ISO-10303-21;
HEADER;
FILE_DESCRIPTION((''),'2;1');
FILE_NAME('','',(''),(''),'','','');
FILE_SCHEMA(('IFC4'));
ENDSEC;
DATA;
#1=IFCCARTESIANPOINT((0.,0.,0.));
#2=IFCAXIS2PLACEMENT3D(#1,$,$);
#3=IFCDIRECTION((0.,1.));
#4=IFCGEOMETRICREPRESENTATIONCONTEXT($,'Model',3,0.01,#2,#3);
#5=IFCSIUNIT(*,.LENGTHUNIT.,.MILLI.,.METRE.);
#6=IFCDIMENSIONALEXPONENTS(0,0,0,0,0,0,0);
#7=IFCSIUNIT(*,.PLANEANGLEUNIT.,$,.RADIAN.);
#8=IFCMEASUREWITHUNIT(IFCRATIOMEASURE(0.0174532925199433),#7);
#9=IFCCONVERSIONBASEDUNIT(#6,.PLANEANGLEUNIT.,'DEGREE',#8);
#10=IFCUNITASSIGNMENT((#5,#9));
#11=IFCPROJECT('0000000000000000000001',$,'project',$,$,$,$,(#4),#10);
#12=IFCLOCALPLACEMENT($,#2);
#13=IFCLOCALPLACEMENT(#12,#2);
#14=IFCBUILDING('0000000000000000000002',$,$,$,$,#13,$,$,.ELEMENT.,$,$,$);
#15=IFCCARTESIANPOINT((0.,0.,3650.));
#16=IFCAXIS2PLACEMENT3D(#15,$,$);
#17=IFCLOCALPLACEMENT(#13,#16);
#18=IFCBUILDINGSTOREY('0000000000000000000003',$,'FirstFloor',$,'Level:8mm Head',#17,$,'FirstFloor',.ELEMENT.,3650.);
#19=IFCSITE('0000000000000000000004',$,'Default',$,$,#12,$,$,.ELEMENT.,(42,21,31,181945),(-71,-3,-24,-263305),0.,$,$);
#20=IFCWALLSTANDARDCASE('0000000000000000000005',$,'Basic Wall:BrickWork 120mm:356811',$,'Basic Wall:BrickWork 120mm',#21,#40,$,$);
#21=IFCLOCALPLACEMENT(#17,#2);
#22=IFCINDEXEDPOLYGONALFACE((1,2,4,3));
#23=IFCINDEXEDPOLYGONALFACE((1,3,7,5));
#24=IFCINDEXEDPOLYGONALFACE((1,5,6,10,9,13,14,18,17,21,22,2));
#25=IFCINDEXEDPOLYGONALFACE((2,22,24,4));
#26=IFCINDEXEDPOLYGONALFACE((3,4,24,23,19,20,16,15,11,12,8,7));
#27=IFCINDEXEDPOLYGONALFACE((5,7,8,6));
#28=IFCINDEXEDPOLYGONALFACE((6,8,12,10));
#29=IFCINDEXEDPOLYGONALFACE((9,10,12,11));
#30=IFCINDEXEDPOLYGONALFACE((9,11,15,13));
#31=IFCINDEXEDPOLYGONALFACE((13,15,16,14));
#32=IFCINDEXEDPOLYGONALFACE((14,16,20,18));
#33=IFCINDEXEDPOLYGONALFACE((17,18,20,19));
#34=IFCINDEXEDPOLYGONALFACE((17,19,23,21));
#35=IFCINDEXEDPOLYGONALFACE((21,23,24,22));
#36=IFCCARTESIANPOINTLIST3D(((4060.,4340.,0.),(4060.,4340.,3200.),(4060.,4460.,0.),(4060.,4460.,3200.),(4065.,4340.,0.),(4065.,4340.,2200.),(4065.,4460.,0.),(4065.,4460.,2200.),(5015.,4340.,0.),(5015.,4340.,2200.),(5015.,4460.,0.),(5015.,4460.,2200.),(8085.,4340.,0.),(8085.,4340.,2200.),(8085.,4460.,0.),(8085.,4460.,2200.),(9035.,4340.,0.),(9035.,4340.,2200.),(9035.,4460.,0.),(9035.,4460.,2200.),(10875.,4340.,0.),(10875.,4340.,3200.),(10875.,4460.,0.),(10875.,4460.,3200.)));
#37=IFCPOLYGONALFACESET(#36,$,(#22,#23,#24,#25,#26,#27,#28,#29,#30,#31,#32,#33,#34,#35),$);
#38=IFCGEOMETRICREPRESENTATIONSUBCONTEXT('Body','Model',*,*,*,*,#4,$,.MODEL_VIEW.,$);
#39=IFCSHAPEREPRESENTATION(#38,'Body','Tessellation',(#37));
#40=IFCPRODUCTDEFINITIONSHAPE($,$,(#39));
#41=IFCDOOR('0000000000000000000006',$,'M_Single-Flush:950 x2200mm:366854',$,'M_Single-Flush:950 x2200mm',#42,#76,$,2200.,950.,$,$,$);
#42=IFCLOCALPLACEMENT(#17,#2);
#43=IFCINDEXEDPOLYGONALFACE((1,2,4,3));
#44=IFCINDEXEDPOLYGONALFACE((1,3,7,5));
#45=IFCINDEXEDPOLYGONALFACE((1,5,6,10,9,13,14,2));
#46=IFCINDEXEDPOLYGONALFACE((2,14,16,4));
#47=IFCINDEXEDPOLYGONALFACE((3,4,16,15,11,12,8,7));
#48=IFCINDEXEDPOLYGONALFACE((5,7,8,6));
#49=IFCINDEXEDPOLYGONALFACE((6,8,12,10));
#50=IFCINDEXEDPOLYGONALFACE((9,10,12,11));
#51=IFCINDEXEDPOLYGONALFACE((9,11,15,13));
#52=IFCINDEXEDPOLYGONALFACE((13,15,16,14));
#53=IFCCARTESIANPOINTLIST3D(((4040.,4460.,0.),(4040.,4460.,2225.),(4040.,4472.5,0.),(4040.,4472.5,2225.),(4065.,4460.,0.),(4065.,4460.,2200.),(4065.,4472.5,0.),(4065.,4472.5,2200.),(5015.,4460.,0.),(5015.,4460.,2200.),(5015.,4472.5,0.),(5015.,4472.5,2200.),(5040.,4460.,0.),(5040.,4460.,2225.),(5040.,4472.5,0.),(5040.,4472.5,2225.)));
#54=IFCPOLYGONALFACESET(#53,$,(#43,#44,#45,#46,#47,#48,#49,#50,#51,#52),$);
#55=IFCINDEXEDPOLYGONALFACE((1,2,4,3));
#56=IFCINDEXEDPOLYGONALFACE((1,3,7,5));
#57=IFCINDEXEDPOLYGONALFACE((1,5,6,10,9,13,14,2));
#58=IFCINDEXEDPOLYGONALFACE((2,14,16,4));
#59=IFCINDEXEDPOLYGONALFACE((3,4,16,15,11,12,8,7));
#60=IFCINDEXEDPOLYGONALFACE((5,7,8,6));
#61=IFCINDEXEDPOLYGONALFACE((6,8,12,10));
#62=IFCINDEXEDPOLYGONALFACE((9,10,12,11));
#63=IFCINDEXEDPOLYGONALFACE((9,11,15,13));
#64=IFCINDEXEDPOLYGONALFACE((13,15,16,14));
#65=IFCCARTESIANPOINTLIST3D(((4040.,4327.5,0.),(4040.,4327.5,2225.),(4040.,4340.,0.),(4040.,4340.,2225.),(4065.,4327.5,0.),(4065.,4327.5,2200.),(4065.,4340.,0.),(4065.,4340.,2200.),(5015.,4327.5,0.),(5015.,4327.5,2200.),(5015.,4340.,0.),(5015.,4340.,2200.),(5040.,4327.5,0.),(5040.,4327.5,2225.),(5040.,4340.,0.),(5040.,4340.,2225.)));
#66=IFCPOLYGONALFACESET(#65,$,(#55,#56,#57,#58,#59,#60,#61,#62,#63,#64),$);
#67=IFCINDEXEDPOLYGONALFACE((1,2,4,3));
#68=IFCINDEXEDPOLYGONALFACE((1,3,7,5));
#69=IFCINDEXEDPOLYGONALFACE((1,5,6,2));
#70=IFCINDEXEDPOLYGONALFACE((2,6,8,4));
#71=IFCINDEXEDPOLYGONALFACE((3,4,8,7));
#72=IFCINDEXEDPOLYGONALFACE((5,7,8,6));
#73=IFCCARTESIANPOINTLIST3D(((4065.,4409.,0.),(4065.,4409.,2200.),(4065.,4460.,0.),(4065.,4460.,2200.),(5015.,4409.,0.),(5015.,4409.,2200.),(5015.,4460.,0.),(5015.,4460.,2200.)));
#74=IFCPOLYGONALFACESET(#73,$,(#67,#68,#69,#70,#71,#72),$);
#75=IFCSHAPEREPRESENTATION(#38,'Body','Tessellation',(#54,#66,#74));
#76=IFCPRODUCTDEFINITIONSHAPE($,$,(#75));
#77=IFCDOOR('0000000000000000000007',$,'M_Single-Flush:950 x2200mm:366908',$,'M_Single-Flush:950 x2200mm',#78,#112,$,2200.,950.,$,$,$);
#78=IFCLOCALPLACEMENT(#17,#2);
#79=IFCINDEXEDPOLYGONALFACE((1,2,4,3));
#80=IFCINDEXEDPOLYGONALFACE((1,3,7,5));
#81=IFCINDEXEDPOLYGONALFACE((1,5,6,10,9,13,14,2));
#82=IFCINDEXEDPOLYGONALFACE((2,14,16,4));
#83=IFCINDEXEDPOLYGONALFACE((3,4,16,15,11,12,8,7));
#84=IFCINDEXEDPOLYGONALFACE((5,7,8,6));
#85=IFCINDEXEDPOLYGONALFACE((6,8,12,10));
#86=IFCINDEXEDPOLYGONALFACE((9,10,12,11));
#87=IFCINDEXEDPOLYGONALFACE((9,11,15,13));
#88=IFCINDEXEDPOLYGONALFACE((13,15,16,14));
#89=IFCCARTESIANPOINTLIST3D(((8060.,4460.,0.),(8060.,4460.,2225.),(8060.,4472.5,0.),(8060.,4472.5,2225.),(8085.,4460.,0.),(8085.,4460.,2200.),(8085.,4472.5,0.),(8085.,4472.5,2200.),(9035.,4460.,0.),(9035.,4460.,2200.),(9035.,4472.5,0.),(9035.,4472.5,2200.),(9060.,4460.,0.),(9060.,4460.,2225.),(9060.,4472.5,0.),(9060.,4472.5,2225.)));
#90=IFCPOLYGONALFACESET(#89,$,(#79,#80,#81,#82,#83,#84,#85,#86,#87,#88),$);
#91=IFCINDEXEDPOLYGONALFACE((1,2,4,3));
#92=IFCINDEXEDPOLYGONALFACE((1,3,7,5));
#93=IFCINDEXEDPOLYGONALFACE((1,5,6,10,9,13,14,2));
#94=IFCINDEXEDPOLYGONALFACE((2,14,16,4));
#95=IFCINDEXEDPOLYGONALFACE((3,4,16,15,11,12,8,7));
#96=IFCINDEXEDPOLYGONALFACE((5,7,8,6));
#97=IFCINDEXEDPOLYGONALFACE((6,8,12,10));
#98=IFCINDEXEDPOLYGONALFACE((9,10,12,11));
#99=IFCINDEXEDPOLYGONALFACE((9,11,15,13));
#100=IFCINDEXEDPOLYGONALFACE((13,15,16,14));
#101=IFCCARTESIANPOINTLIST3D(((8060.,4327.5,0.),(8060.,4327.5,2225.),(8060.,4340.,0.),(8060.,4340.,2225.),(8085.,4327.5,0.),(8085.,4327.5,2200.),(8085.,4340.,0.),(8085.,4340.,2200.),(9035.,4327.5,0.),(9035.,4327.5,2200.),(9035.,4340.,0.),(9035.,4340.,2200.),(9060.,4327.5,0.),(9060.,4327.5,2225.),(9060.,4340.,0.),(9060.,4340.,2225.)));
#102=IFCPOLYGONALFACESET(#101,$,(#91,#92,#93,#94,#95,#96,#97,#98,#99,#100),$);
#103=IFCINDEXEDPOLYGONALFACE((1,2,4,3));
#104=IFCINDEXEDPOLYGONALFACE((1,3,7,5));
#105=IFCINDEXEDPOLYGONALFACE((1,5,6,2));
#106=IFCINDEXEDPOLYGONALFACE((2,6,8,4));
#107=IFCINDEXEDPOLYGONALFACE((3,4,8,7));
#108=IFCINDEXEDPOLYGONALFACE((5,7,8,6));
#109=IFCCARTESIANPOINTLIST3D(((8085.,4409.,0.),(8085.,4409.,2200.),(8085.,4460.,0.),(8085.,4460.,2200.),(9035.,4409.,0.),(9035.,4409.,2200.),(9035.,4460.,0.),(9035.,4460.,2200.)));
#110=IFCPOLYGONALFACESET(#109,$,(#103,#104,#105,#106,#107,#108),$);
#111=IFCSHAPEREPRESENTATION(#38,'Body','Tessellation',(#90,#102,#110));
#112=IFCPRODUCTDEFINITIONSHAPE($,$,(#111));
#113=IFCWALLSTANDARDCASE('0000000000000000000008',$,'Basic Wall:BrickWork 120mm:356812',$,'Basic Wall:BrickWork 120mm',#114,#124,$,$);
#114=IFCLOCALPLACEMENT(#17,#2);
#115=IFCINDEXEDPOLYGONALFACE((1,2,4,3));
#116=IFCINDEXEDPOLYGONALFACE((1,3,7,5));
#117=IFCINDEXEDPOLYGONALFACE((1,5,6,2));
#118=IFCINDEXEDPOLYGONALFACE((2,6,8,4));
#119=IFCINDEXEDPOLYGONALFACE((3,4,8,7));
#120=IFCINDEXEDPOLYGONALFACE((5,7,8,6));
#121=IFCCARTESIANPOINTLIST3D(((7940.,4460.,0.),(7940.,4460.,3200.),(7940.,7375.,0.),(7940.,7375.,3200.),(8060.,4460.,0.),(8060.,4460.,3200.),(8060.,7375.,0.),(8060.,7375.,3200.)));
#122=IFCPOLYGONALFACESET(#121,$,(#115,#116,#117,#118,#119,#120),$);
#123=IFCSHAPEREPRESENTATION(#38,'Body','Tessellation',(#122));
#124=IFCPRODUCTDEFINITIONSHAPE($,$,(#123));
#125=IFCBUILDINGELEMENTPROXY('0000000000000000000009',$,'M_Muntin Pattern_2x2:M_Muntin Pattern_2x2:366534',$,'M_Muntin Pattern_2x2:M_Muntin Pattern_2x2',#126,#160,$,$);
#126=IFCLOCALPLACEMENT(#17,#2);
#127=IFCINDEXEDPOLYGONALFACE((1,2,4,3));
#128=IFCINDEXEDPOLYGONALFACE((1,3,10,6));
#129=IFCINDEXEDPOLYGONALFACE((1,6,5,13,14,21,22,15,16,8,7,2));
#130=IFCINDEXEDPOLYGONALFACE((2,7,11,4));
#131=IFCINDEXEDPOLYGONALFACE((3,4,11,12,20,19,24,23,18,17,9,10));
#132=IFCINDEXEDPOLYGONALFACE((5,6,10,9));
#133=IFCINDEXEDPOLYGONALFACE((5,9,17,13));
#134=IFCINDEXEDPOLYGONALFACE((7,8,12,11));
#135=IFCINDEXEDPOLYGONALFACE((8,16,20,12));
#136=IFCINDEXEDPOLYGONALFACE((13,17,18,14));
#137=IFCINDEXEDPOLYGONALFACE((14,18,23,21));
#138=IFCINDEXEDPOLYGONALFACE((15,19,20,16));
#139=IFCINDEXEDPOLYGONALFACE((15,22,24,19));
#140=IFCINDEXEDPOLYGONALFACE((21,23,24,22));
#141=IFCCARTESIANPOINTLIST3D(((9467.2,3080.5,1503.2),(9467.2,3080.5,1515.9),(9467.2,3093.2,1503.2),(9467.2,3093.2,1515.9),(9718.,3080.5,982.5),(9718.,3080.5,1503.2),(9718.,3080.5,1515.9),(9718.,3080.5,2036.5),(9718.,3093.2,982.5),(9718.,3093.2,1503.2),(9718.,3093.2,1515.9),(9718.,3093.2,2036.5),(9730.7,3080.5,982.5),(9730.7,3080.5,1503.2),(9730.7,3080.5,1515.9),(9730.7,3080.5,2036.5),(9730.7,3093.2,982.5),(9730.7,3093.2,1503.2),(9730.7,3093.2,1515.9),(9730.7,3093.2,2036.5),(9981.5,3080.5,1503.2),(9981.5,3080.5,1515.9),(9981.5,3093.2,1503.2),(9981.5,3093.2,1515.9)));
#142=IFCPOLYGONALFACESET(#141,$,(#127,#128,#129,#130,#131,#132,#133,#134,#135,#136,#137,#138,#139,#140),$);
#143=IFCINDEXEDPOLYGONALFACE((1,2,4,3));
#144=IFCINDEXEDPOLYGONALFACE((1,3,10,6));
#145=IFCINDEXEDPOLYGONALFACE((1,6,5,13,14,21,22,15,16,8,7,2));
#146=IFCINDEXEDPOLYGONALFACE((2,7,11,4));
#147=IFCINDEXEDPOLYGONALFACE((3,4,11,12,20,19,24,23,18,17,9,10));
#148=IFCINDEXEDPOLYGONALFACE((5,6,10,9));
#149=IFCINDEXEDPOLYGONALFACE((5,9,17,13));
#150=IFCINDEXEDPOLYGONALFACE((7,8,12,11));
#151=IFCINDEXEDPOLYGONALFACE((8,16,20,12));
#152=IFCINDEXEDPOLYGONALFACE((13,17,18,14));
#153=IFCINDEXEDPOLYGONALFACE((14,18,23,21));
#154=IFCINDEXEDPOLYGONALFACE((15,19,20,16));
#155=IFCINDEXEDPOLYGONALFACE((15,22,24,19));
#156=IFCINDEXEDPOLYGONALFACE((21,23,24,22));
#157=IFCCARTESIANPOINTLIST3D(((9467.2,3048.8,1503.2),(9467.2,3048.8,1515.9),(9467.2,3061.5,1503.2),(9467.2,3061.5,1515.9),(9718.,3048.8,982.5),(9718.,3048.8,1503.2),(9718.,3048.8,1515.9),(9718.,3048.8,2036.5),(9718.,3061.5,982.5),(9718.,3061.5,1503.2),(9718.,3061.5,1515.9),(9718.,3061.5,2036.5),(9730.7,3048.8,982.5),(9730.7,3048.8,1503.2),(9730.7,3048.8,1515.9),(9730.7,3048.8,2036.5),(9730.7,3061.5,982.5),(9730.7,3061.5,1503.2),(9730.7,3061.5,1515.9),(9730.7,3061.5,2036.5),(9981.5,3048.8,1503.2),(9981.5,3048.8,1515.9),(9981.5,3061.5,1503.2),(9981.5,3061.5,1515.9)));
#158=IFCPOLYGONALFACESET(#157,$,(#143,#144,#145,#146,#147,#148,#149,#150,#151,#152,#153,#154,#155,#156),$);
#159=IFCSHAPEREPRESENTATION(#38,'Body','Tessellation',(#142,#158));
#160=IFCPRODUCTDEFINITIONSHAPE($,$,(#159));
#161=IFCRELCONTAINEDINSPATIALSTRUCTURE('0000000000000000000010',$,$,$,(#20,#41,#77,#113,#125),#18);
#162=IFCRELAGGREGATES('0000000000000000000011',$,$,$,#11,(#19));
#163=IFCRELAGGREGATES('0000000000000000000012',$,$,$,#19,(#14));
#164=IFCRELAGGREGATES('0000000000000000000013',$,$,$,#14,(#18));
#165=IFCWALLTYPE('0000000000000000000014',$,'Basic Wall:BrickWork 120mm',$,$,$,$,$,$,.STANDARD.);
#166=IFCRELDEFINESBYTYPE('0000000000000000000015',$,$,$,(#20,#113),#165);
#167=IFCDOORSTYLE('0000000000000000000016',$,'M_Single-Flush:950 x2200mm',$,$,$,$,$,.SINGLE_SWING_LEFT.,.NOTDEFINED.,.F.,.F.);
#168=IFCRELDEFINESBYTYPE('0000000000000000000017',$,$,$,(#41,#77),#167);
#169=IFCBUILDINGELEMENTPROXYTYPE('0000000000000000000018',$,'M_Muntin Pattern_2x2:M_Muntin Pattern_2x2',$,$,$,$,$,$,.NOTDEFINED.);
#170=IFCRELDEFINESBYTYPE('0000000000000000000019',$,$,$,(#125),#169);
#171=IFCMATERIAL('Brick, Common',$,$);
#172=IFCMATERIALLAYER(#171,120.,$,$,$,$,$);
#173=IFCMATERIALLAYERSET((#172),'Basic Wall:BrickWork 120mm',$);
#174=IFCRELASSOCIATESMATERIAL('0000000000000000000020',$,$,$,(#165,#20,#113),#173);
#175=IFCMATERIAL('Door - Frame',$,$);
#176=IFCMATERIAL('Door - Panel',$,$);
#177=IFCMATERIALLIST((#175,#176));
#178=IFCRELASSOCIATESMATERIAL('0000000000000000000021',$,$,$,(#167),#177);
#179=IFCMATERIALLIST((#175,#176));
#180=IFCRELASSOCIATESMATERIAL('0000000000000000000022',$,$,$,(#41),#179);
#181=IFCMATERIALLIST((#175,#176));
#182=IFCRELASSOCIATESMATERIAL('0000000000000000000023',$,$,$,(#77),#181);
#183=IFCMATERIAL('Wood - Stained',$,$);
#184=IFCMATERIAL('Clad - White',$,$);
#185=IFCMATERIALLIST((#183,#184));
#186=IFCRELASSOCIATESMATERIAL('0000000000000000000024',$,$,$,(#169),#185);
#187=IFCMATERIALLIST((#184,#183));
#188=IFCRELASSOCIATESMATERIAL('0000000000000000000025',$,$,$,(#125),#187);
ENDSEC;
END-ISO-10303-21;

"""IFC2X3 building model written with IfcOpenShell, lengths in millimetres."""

from ifc_helpers import new_model, entity, si_unit, converted_unit, direction, frame, frame_2d, origin, place, context, subcontext, project, spatial, polyline, rectangle, outline, extrude, source, transform, mapped, material, material_list, layer, layer_set, layer_usage, type_object, type_shapes, element, fill, save


model = new_model("IFC2X3")

# Units and contexts
model_context = context("Model", 3, precision=0.01, world=origin(), true_north=direction((0.0, 1.0)))
body_context = subcontext(model_context, "Body", "Model", "MODEL_VIEW")
ifc_project = project(units=[si_unit("LENGTHUNIT", "METRE", prefix="MILLI"), converted_unit("PLANEANGLEUNIT", "DEGREE", entity("IfcRatioMeasure", 0.0174532925199433), si_unit("PLANEANGLEUNIT", "RADIAN"), dimensions=[0, 0, 0, 0, 0, 0, 0])], contexts=[model_context])

# Site, building, storey
site_placement = place(None, origin())
site = spatial("IfcSite", under=ifc_project, at=site_placement, Name="Default", CompositionType="ELEMENT", RefLatitude=(42, 21, 31, 181945), RefLongitude=(-71, -3, -24, -263305), RefElevation=0.0)
building_placement = place(site_placement, origin())
building = spatial("IfcBuilding", under=site, at=building_placement, CompositionType="ELEMENT")
storey_placement = place(building_placement, frame((0.0, 0.0, 3650.0)))
storey = spatial("IfcBuildingStorey", under=building, at=storey_placement, Name="FirstFloor", ObjectType="Level:8mm Head", LongName="FirstFloor", CompositionType="ELEMENT", Elevation=3650.0)

# Shared definitions
ifc_material_1 = material(Name="Brick, Common")

# Wall, openings, doors
ifc_layer_1 = layer(ifc_material_1, 120.0)
ifc_layer_set_1 = layer_set([ifc_layer_1], Name="Basic Wall:BrickWork 120mm")
ifc_layer_usage_1 = layer_usage(ifc_layer_set_1, "AXIS2", "NEGATIVE", 60.0)
wall_type_1 = type_object("IfcWallType", Name="Basic Wall:BrickWork 120mm", PredefinedType="STANDARD", material=ifc_layer_set_1)
wall_1_placement = place(storey_placement, frame((10875.0, 4400.0, 0.0), z_axis=(0.0, 0.0, 1.0), x_axis=(-1.0, 0.0, 0.0)))
wall_1 = element("IfcWallStandardCase", 1, at=wall_1_placement, inside=storey, type_object=wall_type_1, material=ifc_layer_usage_1, Name="Basic Wall:BrickWork 120mm:356811", ObjectType="Basic Wall:BrickWork 120mm", context=body_context, shape_type="SweptSolid", body=[
    extrude(rectangle(XDim=6815.0, YDim=120.0, at=frame_2d((3407.5, 0.0), x_axis=(-1.0, 0.0))), origin(), (0.0, 0.0, 1.0), 3200.0),
])
opening_1_placement = place(wall_1_placement, frame((6810.0, 60.0, 0.0)))
opening_1 = element("IfcOpeningElement", 2, at=opening_1_placement, cuts=wall_1, ObjectType="Opening", context=body_context, shape_type="SweptSolid", body=[
    extrude(rectangle(XDim=950.0, YDim=2200.0, at=frame_2d((1100.0, 475.0), x_axis=(0.0, -1.0))), frame((0.0, 0.0, 0.0), z_axis=(0.0, -1.0, 0.0), x_axis=(0.0, 0.0, 1.0)), (0.0, 0.0, 1.0), 120.0),
])
opening_2_placement = place(wall_1_placement, frame((2790.0, 60.0, 0.0)))
opening_2 = element("IfcOpeningElement", 3, at=opening_2_placement, cuts=wall_1, ObjectType="Opening", context=body_context, shape_type="SweptSolid", body=[
    extrude(rectangle(XDim=950.0, YDim=2200.0, at=frame_2d((1100.0, 475.0), x_axis=(0.0, -1.0))), frame((0.0, 0.0, 0.0), z_axis=(0.0, -1.0, 0.0), x_axis=(0.0, 0.0, 1.0)), (0.0, 0.0, 1.0), 120.0),
])
ifc_material_2 = material(Name="Door - Frame")
ifc_material_3 = material(Name="Door - Panel")
ifc_material_list_1 = material_list([ifc_material_2, ifc_material_3])
ifc_material_list_2 = material_list([ifc_material_2, ifc_material_3])
door_style = type_object("IfcDoorStyle", Name="M_Single-Flush:950 x2200mm", ConstructionType="NOTDEFINED", OperationType="SINGLE_SWING_LEFT", ParameterTakesPrecedence=False, Sizeable=False, material=ifc_material_list_2)
shared_shape_1 = source(origin(), body_context, "Body", "SweptSolid", [
    extrude(outline(polyline([(-500.0, -1118.8), (500.0, -1118.8), (500.0, 1106.2), (475.0, 1106.2), (475.0, -1093.8), (-475.0, -1093.8), (-475.0, 1106.2), (-500.0, 1106.2), (-500.0, -1118.8)])), frame((475.0, 132.5, 1106.2), z_axis=(0.0, -1.0, 0.0), x_axis=(-1.0, 0.0, 0.0)), (0.0, 0.0, 1.0), 12.5),
    extrude(outline(polyline([(-1118.8, -500.0), (1106.2, -500.0), (1106.2, -475.0), (-1093.8, -475.0), (-1093.8, 475.0), (1106.2, 475.0), (1106.2, 500.0), (-1118.8, 500.0), (-1118.8, -500.0)])), frame((475.0, 0.0, 1106.2), z_axis=(0.0, -1.0, 0.0), x_axis=(0.0, 0.0, -1.0)), (0.0, 0.0, 1.0), 12.5),
    extrude(rectangle(XDim=950.0, YDim=51.0, at=frame_2d((0.0, 0.0), x_axis=(1.0, 0.0))), frame((475.0, 94.5, 0.0)), (0.0, 0.0, 1.0), 2200.0),
])
type_shapes(door_style, [shared_shape_1])
door_1_placement = place(opening_1_placement, frame((0.0, 0.0, 0.0), z_axis=(0.0, 0.0, 1.0), x_axis=(-1.0, 0.0, 0.0)))
door_1 = element("IfcDoor", 4, at=door_1_placement, inside=storey, type_object=door_style, material=ifc_material_list_1, Name="M_Single-Flush:950 x2200mm:366854", ObjectType="M_Single-Flush:950 x2200mm", OverallHeight=2200.0, OverallWidth=950.0, context=body_context, shape_type="MappedRepresentation", body=[
    mapped(shared_shape_1, transform((0.0, 0.0, 0.0), scale=1.0)),
])
fill(opening_1, door_1)
ifc_material_list_3 = material_list([ifc_material_2, ifc_material_3])
door_2_placement = place(opening_2_placement, frame((0.0, 0.0, 0.0), z_axis=(0.0, 0.0, 1.0), x_axis=(-1.0, 0.0, 0.0)))
door_2 = element("IfcDoor", 5, at=door_2_placement, inside=storey, type_object=door_style, material=ifc_material_list_3, Name="M_Single-Flush:950 x2200mm:366908", ObjectType="M_Single-Flush:950 x2200mm", OverallHeight=2200.0, OverallWidth=950.0, context=body_context, shape_type="MappedRepresentation", body=[
    mapped(shared_shape_1, transform((0.0, 0.0, 0.0), scale=1.0)),
])
fill(opening_2, door_2)

# Wall
ifc_layer_usage_2 = layer_usage(ifc_layer_set_1, "AXIS2", "NEGATIVE", 60.0)
wall_2_placement = place(storey_placement, frame((8000.0, 7375.0, 0.0), z_axis=(0.0, 0.0, 1.0), x_axis=(0.0, -1.0, 0.0)))
element("IfcWallStandardCase", 6, at=wall_2_placement, inside=storey, type_object=wall_type_1, material=ifc_layer_usage_2, Name="Basic Wall:BrickWork 120mm:356812", ObjectType="Basic Wall:BrickWork 120mm", context=body_context, shape_type="SweptSolid", body=[
    extrude(rectangle(XDim=2915.0, YDim=120.0, at=frame_2d((1457.5, 0.0), x_axis=(-1.0, 0.0))), origin(), (0.0, 0.0, 1.0), 3200.0),
])

# Building element proxy
ifc_material_4 = material(Name="Clad - White")
ifc_material_5 = material(Name="Wood - Stained")
ifc_material_list_4 = material_list([ifc_material_4, ifc_material_5])
ifc_material_list_5 = material_list([ifc_material_5, ifc_material_4])
building_element_proxy_type_1 = type_object("IfcBuildingElementProxyType", Name="M_Muntin Pattern_2x2:M_Muntin Pattern_2x2", PredefinedType="NOTDEFINED", material=ifc_material_list_5)
shared_shape_2 = source(origin(), body_context, "Body", "SweptSolid", [
    extrude(outline(polyline([(6.4, -6.4), (527.0, -6.4), (527.0, 6.3), (6.4, 6.3), (6.4, 257.1), (-6.3, 257.1), (-6.3, 6.3), (-527.0, 6.3), (-527.0, -6.4), (-6.3, -6.4), (-6.3, -257.1), (6.4, -257.1), (6.4, -6.4)])), frame((0.0, 9.5, 527.0), z_axis=(0.0, 1.0, 0.0), x_axis=(0.0, 0.0, 1.0)), (0.0, 0.0, 1.0), 12.7),
    extrude(outline(polyline([(6.4, -6.4), (527.0, -6.4), (527.0, 6.3), (6.4, 6.3), (6.4, 257.1), (-6.3, 257.1), (-6.3, 6.3), (-527.0, 6.3), (-527.0, -6.4), (-6.3, -6.4), (-6.3, -257.1), (6.4, -257.1), (6.4, -6.4)])), frame((0.0, -22.2, 527.0), z_axis=(0.0, 1.0, 0.0), x_axis=(0.0, 0.0, 1.0)), (0.0, 0.0, 1.0), 12.7),
])
type_shapes(building_element_proxy_type_1, [shared_shape_2])
proxy_1_placement = place(storey_placement, frame((9724.4, 3071.0, 982.5)))
element("IfcBuildingElementProxy", 7, at=proxy_1_placement, inside=storey, type_object=building_element_proxy_type_1, material=ifc_material_list_4, Name="M_Muntin Pattern_2x2:M_Muntin Pattern_2x2:366534", ObjectType="M_Muntin Pattern_2x2:M_Muntin Pattern_2x2", context=body_context, shape_type="MappedRepresentation", body=[
    mapped(shared_shape_2, transform((0.0, 0.0, 0.0), scale=1.0)),
])

save(model, "model.ifc")
